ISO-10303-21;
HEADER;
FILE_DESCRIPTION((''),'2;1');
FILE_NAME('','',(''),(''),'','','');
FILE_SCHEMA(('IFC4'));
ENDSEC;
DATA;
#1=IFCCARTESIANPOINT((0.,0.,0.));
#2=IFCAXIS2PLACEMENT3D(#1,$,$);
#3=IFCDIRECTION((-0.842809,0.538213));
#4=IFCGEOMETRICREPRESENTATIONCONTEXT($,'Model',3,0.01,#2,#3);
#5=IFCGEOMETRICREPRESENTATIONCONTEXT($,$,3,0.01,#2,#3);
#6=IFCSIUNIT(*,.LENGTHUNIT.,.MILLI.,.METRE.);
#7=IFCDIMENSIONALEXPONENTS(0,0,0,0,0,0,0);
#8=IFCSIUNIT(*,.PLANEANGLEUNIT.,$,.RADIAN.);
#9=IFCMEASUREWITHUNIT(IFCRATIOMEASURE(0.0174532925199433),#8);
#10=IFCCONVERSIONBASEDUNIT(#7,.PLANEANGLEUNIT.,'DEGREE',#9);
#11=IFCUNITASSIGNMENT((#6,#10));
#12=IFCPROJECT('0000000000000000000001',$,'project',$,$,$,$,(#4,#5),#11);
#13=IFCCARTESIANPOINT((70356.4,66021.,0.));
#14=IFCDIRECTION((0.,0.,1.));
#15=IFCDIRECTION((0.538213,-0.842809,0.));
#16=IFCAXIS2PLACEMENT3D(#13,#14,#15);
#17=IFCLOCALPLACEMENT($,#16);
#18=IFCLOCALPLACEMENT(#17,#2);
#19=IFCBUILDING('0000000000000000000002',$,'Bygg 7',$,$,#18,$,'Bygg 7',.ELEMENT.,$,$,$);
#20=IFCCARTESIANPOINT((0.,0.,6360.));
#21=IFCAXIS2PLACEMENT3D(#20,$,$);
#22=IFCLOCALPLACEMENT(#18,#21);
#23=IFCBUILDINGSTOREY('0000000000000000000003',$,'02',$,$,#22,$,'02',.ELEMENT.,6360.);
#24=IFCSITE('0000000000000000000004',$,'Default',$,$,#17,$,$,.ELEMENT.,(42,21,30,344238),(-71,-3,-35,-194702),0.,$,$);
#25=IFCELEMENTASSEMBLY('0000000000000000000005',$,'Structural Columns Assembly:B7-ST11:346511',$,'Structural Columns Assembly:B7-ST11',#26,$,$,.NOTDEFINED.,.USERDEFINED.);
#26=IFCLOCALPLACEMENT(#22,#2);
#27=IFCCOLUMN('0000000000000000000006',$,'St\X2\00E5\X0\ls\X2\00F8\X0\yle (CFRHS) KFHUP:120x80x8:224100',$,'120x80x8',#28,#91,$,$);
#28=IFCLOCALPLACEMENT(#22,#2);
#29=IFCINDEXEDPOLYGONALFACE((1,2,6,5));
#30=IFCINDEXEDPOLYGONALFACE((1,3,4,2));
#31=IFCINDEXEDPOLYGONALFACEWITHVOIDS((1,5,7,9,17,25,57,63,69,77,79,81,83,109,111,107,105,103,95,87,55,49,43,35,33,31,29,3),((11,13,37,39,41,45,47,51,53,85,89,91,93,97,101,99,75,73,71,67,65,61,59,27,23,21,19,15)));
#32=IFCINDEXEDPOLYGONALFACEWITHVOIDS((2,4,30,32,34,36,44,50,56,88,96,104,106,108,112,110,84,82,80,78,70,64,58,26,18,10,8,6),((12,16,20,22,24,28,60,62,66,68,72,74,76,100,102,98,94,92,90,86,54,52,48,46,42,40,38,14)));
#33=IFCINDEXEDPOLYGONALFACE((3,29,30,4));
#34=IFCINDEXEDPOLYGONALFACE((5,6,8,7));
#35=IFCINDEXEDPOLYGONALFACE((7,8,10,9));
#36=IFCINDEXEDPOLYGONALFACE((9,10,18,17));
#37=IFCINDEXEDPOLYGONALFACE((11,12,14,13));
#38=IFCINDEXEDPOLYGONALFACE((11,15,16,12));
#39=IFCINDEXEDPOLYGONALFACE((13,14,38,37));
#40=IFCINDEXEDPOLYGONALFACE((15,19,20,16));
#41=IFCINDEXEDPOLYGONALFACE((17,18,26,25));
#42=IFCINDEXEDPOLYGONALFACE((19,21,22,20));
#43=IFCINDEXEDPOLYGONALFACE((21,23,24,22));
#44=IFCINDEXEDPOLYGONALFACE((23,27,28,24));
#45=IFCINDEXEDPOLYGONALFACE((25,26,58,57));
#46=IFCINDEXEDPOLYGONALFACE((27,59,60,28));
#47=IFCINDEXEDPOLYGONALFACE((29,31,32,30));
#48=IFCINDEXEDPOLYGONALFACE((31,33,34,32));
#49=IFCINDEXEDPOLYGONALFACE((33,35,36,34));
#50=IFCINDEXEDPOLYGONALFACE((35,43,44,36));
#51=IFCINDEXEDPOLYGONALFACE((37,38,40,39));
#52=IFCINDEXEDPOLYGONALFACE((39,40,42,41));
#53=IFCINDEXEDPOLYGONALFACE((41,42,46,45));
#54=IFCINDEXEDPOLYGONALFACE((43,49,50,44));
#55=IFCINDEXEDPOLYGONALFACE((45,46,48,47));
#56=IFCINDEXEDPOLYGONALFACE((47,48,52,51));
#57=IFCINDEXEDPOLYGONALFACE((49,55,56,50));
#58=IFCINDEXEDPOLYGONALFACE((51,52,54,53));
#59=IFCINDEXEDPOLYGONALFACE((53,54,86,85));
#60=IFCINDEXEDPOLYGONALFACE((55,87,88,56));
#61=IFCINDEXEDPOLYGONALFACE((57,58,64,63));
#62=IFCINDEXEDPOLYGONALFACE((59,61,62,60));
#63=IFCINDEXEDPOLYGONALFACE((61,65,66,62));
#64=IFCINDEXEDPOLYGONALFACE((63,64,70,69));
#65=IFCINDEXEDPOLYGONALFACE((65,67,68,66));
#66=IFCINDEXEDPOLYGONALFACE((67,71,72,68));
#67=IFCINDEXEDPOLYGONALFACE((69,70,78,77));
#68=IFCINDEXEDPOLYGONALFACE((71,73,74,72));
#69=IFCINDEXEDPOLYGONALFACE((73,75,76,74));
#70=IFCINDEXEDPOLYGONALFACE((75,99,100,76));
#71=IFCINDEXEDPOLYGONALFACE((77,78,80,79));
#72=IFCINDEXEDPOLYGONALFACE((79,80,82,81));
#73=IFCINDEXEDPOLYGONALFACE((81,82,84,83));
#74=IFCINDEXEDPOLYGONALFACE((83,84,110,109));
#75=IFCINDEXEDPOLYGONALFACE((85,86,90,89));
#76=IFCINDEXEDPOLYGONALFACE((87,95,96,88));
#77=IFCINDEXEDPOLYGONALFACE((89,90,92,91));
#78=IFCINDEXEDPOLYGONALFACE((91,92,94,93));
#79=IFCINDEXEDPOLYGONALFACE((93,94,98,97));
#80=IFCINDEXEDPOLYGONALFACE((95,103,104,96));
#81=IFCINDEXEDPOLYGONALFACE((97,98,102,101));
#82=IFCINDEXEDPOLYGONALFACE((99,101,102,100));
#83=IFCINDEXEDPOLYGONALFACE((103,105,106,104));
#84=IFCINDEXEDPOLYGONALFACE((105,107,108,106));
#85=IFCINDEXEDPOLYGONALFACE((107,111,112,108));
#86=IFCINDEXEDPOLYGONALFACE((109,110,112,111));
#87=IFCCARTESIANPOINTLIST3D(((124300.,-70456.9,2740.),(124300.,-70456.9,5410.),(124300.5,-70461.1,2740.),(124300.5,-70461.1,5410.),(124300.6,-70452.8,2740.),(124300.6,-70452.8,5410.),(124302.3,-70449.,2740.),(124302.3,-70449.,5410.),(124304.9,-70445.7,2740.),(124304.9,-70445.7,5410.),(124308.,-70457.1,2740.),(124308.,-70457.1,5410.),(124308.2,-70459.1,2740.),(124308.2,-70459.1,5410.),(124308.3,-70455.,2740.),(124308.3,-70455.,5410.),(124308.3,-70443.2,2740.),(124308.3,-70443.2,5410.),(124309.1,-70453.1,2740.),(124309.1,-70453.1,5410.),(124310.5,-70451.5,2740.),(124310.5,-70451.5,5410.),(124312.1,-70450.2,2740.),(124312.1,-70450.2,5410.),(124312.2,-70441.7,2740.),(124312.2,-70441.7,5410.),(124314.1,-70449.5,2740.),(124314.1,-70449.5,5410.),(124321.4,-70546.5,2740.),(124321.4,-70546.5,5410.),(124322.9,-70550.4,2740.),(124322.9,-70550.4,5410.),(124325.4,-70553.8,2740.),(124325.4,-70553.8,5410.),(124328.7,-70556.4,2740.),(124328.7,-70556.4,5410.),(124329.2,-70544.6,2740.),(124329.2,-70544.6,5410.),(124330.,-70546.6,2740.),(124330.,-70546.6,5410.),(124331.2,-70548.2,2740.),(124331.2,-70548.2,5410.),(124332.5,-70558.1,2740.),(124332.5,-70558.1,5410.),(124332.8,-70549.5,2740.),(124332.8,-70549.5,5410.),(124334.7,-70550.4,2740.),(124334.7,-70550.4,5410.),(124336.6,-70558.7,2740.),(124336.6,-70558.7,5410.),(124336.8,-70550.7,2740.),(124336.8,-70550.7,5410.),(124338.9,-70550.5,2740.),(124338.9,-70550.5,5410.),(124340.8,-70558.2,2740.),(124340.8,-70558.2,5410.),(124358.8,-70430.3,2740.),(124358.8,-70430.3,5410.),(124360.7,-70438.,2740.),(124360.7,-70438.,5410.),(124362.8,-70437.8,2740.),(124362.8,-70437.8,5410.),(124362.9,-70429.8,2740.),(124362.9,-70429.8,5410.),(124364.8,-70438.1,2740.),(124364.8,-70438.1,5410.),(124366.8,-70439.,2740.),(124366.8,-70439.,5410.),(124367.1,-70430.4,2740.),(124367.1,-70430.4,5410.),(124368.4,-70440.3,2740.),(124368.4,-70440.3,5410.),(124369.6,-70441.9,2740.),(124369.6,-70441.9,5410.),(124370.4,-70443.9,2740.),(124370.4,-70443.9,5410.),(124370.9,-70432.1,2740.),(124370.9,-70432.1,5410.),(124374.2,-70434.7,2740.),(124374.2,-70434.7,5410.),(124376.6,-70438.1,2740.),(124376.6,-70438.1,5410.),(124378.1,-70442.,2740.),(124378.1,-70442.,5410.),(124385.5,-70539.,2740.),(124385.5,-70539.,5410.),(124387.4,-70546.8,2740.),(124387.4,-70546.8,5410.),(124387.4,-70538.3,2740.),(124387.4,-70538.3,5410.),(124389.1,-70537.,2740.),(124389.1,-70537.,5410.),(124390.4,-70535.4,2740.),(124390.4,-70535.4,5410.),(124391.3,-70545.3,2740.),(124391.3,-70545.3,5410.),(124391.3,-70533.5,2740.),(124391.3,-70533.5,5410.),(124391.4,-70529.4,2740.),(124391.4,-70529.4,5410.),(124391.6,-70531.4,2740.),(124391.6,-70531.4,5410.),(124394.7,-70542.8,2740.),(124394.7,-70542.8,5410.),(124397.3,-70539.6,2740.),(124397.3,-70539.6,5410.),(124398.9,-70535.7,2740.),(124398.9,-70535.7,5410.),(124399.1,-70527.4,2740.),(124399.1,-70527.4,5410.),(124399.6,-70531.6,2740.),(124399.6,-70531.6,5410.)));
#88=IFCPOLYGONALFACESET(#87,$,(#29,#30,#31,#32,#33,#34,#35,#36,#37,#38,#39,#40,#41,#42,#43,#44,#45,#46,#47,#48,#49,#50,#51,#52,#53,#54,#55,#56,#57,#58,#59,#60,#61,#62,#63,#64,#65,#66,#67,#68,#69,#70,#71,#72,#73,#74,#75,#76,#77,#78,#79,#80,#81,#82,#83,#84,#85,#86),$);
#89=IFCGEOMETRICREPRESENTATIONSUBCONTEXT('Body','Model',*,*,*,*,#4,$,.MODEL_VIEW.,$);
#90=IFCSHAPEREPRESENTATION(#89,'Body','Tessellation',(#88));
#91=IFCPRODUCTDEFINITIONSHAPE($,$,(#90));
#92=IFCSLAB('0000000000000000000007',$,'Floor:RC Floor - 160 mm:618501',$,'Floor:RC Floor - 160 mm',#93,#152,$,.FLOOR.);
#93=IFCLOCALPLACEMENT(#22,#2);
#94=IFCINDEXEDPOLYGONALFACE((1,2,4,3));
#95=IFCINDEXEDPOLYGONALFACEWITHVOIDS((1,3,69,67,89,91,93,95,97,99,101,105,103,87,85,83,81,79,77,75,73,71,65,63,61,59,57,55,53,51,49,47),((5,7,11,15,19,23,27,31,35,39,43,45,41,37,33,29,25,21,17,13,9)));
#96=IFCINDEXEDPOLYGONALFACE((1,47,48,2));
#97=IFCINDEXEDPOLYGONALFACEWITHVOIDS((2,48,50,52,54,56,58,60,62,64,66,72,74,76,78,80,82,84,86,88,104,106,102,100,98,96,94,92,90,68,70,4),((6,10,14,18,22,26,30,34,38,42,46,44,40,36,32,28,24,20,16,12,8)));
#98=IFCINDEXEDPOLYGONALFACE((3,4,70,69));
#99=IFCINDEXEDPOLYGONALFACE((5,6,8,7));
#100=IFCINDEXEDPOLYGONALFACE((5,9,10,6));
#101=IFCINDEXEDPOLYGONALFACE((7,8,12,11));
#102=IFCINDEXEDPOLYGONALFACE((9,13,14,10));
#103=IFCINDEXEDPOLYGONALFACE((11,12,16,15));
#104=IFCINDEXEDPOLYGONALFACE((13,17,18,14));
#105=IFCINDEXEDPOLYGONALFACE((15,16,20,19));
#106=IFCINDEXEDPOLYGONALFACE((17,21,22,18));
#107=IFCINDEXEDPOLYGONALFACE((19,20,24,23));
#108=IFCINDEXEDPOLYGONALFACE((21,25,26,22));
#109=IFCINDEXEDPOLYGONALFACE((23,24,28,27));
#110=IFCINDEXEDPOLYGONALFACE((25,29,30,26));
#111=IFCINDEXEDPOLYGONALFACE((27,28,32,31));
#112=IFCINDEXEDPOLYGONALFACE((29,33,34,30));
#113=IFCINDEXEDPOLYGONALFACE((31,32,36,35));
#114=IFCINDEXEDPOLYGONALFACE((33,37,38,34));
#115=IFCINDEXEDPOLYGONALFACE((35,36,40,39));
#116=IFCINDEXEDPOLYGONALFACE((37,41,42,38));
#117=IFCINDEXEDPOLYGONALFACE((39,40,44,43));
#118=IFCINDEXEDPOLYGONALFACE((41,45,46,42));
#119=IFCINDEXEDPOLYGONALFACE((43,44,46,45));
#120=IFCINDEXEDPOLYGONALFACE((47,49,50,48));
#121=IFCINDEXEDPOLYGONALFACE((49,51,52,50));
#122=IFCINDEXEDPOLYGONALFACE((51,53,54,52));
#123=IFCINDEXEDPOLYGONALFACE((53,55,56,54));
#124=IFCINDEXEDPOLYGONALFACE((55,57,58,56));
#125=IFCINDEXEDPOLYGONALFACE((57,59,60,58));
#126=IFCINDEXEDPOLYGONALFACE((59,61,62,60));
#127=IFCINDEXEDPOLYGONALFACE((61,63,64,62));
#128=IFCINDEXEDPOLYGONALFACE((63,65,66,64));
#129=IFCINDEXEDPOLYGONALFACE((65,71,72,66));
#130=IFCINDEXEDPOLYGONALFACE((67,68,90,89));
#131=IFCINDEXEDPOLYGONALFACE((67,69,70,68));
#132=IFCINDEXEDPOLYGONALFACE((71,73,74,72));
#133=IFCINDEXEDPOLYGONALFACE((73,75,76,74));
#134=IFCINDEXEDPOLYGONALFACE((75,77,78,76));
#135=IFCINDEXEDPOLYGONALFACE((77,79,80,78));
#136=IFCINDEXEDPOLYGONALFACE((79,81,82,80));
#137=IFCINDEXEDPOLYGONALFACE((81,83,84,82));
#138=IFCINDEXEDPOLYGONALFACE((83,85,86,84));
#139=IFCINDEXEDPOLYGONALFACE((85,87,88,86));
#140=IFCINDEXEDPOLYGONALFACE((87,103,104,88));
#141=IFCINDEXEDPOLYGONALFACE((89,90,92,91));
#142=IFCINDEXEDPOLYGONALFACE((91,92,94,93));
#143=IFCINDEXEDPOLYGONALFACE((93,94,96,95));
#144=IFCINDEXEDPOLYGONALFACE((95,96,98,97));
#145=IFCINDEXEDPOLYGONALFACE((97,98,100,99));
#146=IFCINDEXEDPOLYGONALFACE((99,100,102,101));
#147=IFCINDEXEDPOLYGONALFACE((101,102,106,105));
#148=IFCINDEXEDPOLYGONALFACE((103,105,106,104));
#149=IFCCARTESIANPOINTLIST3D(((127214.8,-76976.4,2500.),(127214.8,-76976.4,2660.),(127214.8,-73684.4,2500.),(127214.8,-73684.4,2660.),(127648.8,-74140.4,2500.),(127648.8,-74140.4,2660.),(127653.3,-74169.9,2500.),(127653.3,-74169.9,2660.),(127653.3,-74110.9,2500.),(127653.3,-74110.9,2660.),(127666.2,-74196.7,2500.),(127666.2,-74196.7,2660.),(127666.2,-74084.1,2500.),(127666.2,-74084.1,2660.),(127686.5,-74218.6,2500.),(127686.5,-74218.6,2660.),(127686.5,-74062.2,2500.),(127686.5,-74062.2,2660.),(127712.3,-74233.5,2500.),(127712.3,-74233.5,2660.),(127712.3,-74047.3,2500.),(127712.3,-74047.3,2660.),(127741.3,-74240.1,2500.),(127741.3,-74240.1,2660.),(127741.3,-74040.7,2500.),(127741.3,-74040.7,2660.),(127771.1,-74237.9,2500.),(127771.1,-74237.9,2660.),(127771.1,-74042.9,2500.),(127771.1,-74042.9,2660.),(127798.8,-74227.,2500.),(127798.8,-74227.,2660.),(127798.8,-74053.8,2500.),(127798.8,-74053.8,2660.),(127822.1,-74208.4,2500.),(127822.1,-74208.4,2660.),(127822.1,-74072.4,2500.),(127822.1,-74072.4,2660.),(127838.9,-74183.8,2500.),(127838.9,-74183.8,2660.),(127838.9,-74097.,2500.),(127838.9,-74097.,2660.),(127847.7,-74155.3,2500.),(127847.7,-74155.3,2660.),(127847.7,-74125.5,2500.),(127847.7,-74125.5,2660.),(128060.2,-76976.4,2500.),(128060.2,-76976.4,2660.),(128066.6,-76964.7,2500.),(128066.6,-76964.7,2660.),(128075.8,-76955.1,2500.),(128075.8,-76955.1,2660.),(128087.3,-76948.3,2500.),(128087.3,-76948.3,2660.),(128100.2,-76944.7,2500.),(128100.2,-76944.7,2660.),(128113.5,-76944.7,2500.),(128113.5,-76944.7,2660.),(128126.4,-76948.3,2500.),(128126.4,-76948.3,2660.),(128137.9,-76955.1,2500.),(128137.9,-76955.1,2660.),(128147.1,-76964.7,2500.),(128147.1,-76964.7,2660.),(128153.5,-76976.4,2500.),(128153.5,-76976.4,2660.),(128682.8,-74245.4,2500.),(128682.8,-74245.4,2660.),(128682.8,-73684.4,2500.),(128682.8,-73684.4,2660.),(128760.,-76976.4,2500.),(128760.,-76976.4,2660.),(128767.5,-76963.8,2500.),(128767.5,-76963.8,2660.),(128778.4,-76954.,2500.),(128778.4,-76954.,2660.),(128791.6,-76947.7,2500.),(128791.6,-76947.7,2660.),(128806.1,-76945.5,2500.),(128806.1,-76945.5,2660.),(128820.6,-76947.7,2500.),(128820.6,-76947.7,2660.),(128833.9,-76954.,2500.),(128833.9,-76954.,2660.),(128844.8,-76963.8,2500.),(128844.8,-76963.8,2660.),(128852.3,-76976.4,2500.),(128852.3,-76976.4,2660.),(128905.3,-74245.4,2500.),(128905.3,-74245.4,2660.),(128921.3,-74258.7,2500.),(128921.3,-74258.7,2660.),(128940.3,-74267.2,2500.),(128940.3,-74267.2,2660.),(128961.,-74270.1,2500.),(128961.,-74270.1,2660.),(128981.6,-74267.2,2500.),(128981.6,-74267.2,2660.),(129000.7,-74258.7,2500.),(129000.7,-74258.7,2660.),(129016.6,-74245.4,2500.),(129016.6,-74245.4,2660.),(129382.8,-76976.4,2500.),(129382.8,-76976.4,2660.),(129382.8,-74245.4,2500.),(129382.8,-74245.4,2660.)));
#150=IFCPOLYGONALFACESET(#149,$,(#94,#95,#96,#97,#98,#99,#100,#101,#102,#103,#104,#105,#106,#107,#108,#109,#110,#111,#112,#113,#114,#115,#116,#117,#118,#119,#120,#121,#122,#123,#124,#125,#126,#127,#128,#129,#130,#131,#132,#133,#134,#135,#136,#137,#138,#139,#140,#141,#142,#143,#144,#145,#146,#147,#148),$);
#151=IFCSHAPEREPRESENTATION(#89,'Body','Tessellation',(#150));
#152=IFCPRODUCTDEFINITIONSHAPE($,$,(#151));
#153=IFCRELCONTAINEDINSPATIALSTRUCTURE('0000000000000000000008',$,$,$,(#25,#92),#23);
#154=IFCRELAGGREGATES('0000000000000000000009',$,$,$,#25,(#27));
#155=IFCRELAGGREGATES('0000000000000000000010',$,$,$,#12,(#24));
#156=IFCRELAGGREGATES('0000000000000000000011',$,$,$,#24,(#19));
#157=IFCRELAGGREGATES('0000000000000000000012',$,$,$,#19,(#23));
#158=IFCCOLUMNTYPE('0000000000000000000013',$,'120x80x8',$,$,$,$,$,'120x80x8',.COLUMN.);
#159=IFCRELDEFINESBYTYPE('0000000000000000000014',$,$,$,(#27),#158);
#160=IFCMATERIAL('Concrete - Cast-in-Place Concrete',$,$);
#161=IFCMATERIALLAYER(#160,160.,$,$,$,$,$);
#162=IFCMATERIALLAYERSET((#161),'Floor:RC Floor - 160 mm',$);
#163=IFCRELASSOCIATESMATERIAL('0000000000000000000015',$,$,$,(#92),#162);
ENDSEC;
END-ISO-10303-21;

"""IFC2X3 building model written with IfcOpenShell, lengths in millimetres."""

from ifc_helpers import new_model, entity, si_unit, converted_unit, direction, frame, frame_2d, origin, place, context, subcontext, project, spatial, polyline, circle_curve, parameter, trimmed, segment, composite_curve, circle, outline, extrude, source, transform, mapped, material, layer, layer_set, layer_usage, type_object, type_shapes, element, aggregate, save


model = new_model("IFC2X3")

# Units and contexts
model_context = context("Model", 3, precision=0.01, world=origin(), true_north=direction((-0.842809, 0.538213)))
context_of_model = context(None, 3, precision=0.01, world=origin(), true_north=direction((-0.842809, 0.538213)))
body_context = subcontext(model_context, "Body", "Model", "MODEL_VIEW")
ifc_project = project(units=[si_unit("LENGTHUNIT", "METRE", prefix="MILLI"), converted_unit("PLANEANGLEUNIT", "DEGREE", entity("IfcRatioMeasure", 0.0174532925199433), si_unit("PLANEANGLEUNIT", "RADIAN"), dimensions=[0, 0, 0, 0, 0, 0, 0])], contexts=[model_context, context_of_model])

# Site, building, storey
site_placement = place(None, frame((70356.4, 66021.0, 0.0), z_axis=(0.0, 0.0, 1.0), x_axis=(0.538213, -0.842809, 0.0)))
site = spatial("IfcSite", under=ifc_project, at=site_placement, Name="Default", CompositionType="ELEMENT", RefLatitude=(42, 21, 30, 344238), RefLongitude=(-71, -3, -35, -194702), RefElevation=0.0)
building_placement = place(site_placement, origin())
building = spatial("IfcBuilding", under=site, at=building_placement, Name="Bygg 7", LongName="Bygg 7", CompositionType="ELEMENT")
storey_placement = place(building_placement, frame((0.0, 0.0, 6360.0)))
storey = spatial("IfcBuildingStorey", under=building, at=storey_placement, Name="02", LongName="02", CompositionType="ELEMENT", Elevation=6360.0)

# Element assembly, column
assembly_1_placement = place(storey_placement, origin())
assembly_1 = element("IfcElementAssembly", 1, at=assembly_1_placement, inside=storey, Name="Structural Columns Assembly:B7-ST11:346511", ObjectType="Structural Columns Assembly:B7-ST11", AssemblyPlace="NOTDEFINED", PredefinedType="USERDEFINED")
column_type_1 = type_object("IfcColumnType", Name="120x80x8", ElementType="120x80x8", PredefinedType="COLUMN")
shared_shape_1 = source(origin(), body_context, "Body", "SweptSolid", [
    extrude(outline(composite_curve([segment(trimmed(circle_curve(frame_2d((-24.0, 44.0), x_axis=(1.0, 0.0)), 16.0), [parameter(90.0)], [parameter(180.0)], True, "PARAMETER"), True, "CONTINUOUS"), segment(polyline([(-40.0, 44.0), (-40.0, -44.0)]), True, "CONTINUOUS"), segment(trimmed(circle_curve(frame_2d((-24.0, -44.0), x_axis=(1.0, 0.0)), 16.0), [parameter(180.0)], [parameter(270.0)], True, "PARAMETER"), True, "CONTINUOUS"), segment(polyline([(-24.0, -60.0), (24.0, -60.0)]), True, "CONTINUOUS"), segment(trimmed(circle_curve(frame_2d((24.0, -44.0), x_axis=(1.0, 0.0)), 16.0), [parameter(270.0)], [parameter(0.0)], True, "PARAMETER"), True, "CONTINUOUS"), segment(polyline([(40.0, -44.0), (40.0, 44.0)]), True, "CONTINUOUS"), segment(trimmed(circle_curve(frame_2d((24.0, 44.0), x_axis=(1.0, 0.0)), 16.0), [parameter(0.0)], [parameter(90.0)], True, "PARAMETER"), True, "CONTINUOUS"), segment(polyline([(24.0, 60.0), (-24.0, 60.0)]), True, "CONTINUOUS")], self_intersect=False), holes=[composite_curve([segment(polyline([(-24.0, 52.0), (24.0, 52.0)]), True, "CONTINUOUS"), segment(trimmed(circle_curve(frame_2d((24.0, 44.0), x_axis=(1.0, 0.0)), 8.0), [parameter(360.0)], [parameter(90.0)], True, "PARAMETER"), False, "CONTINUOUS"), segment(polyline([(32.0, 44.0), (32.0, -44.0)]), True, "CONTINUOUS"), segment(trimmed(circle_curve(frame_2d((24.0, -44.0), x_axis=(1.0, 0.0)), 8.0), [parameter(270.0)], [parameter(360.0)], True, "PARAMETER"), False, "CONTINUOUS"), segment(polyline([(24.0, -52.0), (-24.0, -52.0)]), True, "CONTINUOUS"), segment(trimmed(circle_curve(frame_2d((-24.0, -44.0), x_axis=(1.0, 0.0)), 8.0), [parameter(180.0)], [parameter(270.0)], True, "PARAMETER"), False, "CONTINUOUS"), segment(polyline([(-32.0, -44.0), (-32.0, 44.0)]), True, "CONTINUOUS"), segment(trimmed(circle_curve(frame_2d((-24.0, 44.0), x_axis=(1.0, 0.0)), 8.0), [parameter(90.0)], [parameter(180.0)], True, "PARAMETER"), False, "CONTINUOUS")], self_intersect=False)]), frame((51.4, 66.0, 0.0), z_axis=(0.0, 0.0, 1.0), x_axis=(-0.971172, -0.238381, 0.0)), (0.0, 0.0, 1.0), 2670.0),
])
type_shapes(column_type_1, [shared_shape_1])
column_1_placement = place(assembly_1_placement, frame((124298.4, -70560.3, 2740.0)))
column_1 = element("IfcColumn", 2, at=column_1_placement, type_object=column_type_1, Name="Stålsøyle (CFRHS) KFHUP:120x80x8:224100", ObjectType="120x80x8", context=body_context, shape_type="MappedRepresentation", body=[
    mapped(shared_shape_1, transform((0.0, 0.0, 0.0), scale=1.0)),
])
aggregate(assembly_1, [column_1])

# Shared definitions
ifc_material_1 = material(Name="Concrete - Cast-in-Place Concrete")

# Slab, openings
ifc_layer_1 = layer(ifc_material_1, 160.0)
ifc_layer_set_1 = layer_set([ifc_layer_1], Name="Floor:RC Floor - 160 mm")
ifc_layer_usage_1 = layer_usage(ifc_layer_set_1, "AXIS3", "POSITIVE", 0.0)
slab_1_placement = place(storey_placement, frame((127214.8, -76976.4, 2500.0)))
slab_1 = element("IfcSlab", 3, at=slab_1_placement, inside=storey, material=ifc_layer_usage_1, Name="Floor:RC Floor - 160 mm:618501", ObjectType="Floor:RC Floor - 160 mm", PredefinedType="FLOOR", context=body_context, shape_type="SweptSolid", body=[
    extrude(outline(polyline([(-384.0, 1646.0), (-384.0, 1085.0), (-1084.0, 1085.0), (-1084.0, -1646.0), (1084.0, -1646.0), (1084.0, 1646.0), (-384.0, 1646.0)])), frame((1084.0, 1646.0, 160.0), z_axis=(0.0, 0.0, -1.0), x_axis=(-1.0, 0.0, 0.0)), (0.0, 0.0, 1.0), 160.0),
])
opening_1_placement = place(storey_placement, frame((127214.8, -76976.4, 2500.0)))
element("IfcOpeningElement", 4, at=opening_1_placement, cuts=slab_1, ObjectType="Opening", context=body_context, shape_type="SweptSolid", body=[
    extrude(circle(Radius=100.0, at=frame_2d((550.0, 1190.0), x_axis=(1.0, 0.0))), frame((1084.0, 1646.0, 160.0), z_axis=(0.0, 0.0, -1.0), x_axis=(-1.0, 0.0, 0.0)), (0.0, 0.0, 1.0), 160.0),
])
opening_2_placement = place(storey_placement, frame((127214.8, -76976.4, 2500.0)))
element("IfcOpeningElement", 5, at=opening_2_placement, cuts=slab_1, ObjectType="Opening", context=body_context, shape_type="SweptSolid", body=[
    extrude(circle(Radius=50.0, at=frame_2d((192.0, -1663.9), x_axis=(1.0, 0.0))), frame((1084.0, 1646.0, 160.0), z_axis=(0.0, 0.0, -1.0), x_axis=(-1.0, 0.0, 0.0)), (0.0, 0.0, 1.0), 160.0),
])
opening_3_placement = place(storey_placement, frame((127214.8, -76976.4, 2500.0)))
element("IfcOpeningElement", 6, at=opening_3_placement, cuts=slab_1, ObjectType="Opening", context=body_context, shape_type="SweptSolid", body=[
    extrude(circle(Radius=50.0, at=frame_2d((-507.3, -1665.2), x_axis=(1.0, 0.0))), frame((1084.0, 1646.0, 160.0), z_axis=(0.0, 0.0, -1.0), x_axis=(-1.0, 0.0, 0.0)), (0.0, 0.0, 1.0), 160.0),
])
opening_4_placement = place(storey_placement, frame((127214.8, -76976.4, 2500.0)))
element("IfcOpeningElement", 7, at=opening_4_placement, cuts=slab_1, ObjectType="Opening", context=body_context, shape_type="SweptSolid", body=[
    extrude(circle(Radius=75.0, at=frame_2d((-662.1, 1135.3), x_axis=(1.0, 0.0))), frame((1084.0, 1646.0, 160.0), z_axis=(0.0, 0.0, -1.0), x_axis=(-1.0, 0.0, 0.0)), (0.0, 0.0, 1.0), 160.0),
])

save(model, "model.ifc")
